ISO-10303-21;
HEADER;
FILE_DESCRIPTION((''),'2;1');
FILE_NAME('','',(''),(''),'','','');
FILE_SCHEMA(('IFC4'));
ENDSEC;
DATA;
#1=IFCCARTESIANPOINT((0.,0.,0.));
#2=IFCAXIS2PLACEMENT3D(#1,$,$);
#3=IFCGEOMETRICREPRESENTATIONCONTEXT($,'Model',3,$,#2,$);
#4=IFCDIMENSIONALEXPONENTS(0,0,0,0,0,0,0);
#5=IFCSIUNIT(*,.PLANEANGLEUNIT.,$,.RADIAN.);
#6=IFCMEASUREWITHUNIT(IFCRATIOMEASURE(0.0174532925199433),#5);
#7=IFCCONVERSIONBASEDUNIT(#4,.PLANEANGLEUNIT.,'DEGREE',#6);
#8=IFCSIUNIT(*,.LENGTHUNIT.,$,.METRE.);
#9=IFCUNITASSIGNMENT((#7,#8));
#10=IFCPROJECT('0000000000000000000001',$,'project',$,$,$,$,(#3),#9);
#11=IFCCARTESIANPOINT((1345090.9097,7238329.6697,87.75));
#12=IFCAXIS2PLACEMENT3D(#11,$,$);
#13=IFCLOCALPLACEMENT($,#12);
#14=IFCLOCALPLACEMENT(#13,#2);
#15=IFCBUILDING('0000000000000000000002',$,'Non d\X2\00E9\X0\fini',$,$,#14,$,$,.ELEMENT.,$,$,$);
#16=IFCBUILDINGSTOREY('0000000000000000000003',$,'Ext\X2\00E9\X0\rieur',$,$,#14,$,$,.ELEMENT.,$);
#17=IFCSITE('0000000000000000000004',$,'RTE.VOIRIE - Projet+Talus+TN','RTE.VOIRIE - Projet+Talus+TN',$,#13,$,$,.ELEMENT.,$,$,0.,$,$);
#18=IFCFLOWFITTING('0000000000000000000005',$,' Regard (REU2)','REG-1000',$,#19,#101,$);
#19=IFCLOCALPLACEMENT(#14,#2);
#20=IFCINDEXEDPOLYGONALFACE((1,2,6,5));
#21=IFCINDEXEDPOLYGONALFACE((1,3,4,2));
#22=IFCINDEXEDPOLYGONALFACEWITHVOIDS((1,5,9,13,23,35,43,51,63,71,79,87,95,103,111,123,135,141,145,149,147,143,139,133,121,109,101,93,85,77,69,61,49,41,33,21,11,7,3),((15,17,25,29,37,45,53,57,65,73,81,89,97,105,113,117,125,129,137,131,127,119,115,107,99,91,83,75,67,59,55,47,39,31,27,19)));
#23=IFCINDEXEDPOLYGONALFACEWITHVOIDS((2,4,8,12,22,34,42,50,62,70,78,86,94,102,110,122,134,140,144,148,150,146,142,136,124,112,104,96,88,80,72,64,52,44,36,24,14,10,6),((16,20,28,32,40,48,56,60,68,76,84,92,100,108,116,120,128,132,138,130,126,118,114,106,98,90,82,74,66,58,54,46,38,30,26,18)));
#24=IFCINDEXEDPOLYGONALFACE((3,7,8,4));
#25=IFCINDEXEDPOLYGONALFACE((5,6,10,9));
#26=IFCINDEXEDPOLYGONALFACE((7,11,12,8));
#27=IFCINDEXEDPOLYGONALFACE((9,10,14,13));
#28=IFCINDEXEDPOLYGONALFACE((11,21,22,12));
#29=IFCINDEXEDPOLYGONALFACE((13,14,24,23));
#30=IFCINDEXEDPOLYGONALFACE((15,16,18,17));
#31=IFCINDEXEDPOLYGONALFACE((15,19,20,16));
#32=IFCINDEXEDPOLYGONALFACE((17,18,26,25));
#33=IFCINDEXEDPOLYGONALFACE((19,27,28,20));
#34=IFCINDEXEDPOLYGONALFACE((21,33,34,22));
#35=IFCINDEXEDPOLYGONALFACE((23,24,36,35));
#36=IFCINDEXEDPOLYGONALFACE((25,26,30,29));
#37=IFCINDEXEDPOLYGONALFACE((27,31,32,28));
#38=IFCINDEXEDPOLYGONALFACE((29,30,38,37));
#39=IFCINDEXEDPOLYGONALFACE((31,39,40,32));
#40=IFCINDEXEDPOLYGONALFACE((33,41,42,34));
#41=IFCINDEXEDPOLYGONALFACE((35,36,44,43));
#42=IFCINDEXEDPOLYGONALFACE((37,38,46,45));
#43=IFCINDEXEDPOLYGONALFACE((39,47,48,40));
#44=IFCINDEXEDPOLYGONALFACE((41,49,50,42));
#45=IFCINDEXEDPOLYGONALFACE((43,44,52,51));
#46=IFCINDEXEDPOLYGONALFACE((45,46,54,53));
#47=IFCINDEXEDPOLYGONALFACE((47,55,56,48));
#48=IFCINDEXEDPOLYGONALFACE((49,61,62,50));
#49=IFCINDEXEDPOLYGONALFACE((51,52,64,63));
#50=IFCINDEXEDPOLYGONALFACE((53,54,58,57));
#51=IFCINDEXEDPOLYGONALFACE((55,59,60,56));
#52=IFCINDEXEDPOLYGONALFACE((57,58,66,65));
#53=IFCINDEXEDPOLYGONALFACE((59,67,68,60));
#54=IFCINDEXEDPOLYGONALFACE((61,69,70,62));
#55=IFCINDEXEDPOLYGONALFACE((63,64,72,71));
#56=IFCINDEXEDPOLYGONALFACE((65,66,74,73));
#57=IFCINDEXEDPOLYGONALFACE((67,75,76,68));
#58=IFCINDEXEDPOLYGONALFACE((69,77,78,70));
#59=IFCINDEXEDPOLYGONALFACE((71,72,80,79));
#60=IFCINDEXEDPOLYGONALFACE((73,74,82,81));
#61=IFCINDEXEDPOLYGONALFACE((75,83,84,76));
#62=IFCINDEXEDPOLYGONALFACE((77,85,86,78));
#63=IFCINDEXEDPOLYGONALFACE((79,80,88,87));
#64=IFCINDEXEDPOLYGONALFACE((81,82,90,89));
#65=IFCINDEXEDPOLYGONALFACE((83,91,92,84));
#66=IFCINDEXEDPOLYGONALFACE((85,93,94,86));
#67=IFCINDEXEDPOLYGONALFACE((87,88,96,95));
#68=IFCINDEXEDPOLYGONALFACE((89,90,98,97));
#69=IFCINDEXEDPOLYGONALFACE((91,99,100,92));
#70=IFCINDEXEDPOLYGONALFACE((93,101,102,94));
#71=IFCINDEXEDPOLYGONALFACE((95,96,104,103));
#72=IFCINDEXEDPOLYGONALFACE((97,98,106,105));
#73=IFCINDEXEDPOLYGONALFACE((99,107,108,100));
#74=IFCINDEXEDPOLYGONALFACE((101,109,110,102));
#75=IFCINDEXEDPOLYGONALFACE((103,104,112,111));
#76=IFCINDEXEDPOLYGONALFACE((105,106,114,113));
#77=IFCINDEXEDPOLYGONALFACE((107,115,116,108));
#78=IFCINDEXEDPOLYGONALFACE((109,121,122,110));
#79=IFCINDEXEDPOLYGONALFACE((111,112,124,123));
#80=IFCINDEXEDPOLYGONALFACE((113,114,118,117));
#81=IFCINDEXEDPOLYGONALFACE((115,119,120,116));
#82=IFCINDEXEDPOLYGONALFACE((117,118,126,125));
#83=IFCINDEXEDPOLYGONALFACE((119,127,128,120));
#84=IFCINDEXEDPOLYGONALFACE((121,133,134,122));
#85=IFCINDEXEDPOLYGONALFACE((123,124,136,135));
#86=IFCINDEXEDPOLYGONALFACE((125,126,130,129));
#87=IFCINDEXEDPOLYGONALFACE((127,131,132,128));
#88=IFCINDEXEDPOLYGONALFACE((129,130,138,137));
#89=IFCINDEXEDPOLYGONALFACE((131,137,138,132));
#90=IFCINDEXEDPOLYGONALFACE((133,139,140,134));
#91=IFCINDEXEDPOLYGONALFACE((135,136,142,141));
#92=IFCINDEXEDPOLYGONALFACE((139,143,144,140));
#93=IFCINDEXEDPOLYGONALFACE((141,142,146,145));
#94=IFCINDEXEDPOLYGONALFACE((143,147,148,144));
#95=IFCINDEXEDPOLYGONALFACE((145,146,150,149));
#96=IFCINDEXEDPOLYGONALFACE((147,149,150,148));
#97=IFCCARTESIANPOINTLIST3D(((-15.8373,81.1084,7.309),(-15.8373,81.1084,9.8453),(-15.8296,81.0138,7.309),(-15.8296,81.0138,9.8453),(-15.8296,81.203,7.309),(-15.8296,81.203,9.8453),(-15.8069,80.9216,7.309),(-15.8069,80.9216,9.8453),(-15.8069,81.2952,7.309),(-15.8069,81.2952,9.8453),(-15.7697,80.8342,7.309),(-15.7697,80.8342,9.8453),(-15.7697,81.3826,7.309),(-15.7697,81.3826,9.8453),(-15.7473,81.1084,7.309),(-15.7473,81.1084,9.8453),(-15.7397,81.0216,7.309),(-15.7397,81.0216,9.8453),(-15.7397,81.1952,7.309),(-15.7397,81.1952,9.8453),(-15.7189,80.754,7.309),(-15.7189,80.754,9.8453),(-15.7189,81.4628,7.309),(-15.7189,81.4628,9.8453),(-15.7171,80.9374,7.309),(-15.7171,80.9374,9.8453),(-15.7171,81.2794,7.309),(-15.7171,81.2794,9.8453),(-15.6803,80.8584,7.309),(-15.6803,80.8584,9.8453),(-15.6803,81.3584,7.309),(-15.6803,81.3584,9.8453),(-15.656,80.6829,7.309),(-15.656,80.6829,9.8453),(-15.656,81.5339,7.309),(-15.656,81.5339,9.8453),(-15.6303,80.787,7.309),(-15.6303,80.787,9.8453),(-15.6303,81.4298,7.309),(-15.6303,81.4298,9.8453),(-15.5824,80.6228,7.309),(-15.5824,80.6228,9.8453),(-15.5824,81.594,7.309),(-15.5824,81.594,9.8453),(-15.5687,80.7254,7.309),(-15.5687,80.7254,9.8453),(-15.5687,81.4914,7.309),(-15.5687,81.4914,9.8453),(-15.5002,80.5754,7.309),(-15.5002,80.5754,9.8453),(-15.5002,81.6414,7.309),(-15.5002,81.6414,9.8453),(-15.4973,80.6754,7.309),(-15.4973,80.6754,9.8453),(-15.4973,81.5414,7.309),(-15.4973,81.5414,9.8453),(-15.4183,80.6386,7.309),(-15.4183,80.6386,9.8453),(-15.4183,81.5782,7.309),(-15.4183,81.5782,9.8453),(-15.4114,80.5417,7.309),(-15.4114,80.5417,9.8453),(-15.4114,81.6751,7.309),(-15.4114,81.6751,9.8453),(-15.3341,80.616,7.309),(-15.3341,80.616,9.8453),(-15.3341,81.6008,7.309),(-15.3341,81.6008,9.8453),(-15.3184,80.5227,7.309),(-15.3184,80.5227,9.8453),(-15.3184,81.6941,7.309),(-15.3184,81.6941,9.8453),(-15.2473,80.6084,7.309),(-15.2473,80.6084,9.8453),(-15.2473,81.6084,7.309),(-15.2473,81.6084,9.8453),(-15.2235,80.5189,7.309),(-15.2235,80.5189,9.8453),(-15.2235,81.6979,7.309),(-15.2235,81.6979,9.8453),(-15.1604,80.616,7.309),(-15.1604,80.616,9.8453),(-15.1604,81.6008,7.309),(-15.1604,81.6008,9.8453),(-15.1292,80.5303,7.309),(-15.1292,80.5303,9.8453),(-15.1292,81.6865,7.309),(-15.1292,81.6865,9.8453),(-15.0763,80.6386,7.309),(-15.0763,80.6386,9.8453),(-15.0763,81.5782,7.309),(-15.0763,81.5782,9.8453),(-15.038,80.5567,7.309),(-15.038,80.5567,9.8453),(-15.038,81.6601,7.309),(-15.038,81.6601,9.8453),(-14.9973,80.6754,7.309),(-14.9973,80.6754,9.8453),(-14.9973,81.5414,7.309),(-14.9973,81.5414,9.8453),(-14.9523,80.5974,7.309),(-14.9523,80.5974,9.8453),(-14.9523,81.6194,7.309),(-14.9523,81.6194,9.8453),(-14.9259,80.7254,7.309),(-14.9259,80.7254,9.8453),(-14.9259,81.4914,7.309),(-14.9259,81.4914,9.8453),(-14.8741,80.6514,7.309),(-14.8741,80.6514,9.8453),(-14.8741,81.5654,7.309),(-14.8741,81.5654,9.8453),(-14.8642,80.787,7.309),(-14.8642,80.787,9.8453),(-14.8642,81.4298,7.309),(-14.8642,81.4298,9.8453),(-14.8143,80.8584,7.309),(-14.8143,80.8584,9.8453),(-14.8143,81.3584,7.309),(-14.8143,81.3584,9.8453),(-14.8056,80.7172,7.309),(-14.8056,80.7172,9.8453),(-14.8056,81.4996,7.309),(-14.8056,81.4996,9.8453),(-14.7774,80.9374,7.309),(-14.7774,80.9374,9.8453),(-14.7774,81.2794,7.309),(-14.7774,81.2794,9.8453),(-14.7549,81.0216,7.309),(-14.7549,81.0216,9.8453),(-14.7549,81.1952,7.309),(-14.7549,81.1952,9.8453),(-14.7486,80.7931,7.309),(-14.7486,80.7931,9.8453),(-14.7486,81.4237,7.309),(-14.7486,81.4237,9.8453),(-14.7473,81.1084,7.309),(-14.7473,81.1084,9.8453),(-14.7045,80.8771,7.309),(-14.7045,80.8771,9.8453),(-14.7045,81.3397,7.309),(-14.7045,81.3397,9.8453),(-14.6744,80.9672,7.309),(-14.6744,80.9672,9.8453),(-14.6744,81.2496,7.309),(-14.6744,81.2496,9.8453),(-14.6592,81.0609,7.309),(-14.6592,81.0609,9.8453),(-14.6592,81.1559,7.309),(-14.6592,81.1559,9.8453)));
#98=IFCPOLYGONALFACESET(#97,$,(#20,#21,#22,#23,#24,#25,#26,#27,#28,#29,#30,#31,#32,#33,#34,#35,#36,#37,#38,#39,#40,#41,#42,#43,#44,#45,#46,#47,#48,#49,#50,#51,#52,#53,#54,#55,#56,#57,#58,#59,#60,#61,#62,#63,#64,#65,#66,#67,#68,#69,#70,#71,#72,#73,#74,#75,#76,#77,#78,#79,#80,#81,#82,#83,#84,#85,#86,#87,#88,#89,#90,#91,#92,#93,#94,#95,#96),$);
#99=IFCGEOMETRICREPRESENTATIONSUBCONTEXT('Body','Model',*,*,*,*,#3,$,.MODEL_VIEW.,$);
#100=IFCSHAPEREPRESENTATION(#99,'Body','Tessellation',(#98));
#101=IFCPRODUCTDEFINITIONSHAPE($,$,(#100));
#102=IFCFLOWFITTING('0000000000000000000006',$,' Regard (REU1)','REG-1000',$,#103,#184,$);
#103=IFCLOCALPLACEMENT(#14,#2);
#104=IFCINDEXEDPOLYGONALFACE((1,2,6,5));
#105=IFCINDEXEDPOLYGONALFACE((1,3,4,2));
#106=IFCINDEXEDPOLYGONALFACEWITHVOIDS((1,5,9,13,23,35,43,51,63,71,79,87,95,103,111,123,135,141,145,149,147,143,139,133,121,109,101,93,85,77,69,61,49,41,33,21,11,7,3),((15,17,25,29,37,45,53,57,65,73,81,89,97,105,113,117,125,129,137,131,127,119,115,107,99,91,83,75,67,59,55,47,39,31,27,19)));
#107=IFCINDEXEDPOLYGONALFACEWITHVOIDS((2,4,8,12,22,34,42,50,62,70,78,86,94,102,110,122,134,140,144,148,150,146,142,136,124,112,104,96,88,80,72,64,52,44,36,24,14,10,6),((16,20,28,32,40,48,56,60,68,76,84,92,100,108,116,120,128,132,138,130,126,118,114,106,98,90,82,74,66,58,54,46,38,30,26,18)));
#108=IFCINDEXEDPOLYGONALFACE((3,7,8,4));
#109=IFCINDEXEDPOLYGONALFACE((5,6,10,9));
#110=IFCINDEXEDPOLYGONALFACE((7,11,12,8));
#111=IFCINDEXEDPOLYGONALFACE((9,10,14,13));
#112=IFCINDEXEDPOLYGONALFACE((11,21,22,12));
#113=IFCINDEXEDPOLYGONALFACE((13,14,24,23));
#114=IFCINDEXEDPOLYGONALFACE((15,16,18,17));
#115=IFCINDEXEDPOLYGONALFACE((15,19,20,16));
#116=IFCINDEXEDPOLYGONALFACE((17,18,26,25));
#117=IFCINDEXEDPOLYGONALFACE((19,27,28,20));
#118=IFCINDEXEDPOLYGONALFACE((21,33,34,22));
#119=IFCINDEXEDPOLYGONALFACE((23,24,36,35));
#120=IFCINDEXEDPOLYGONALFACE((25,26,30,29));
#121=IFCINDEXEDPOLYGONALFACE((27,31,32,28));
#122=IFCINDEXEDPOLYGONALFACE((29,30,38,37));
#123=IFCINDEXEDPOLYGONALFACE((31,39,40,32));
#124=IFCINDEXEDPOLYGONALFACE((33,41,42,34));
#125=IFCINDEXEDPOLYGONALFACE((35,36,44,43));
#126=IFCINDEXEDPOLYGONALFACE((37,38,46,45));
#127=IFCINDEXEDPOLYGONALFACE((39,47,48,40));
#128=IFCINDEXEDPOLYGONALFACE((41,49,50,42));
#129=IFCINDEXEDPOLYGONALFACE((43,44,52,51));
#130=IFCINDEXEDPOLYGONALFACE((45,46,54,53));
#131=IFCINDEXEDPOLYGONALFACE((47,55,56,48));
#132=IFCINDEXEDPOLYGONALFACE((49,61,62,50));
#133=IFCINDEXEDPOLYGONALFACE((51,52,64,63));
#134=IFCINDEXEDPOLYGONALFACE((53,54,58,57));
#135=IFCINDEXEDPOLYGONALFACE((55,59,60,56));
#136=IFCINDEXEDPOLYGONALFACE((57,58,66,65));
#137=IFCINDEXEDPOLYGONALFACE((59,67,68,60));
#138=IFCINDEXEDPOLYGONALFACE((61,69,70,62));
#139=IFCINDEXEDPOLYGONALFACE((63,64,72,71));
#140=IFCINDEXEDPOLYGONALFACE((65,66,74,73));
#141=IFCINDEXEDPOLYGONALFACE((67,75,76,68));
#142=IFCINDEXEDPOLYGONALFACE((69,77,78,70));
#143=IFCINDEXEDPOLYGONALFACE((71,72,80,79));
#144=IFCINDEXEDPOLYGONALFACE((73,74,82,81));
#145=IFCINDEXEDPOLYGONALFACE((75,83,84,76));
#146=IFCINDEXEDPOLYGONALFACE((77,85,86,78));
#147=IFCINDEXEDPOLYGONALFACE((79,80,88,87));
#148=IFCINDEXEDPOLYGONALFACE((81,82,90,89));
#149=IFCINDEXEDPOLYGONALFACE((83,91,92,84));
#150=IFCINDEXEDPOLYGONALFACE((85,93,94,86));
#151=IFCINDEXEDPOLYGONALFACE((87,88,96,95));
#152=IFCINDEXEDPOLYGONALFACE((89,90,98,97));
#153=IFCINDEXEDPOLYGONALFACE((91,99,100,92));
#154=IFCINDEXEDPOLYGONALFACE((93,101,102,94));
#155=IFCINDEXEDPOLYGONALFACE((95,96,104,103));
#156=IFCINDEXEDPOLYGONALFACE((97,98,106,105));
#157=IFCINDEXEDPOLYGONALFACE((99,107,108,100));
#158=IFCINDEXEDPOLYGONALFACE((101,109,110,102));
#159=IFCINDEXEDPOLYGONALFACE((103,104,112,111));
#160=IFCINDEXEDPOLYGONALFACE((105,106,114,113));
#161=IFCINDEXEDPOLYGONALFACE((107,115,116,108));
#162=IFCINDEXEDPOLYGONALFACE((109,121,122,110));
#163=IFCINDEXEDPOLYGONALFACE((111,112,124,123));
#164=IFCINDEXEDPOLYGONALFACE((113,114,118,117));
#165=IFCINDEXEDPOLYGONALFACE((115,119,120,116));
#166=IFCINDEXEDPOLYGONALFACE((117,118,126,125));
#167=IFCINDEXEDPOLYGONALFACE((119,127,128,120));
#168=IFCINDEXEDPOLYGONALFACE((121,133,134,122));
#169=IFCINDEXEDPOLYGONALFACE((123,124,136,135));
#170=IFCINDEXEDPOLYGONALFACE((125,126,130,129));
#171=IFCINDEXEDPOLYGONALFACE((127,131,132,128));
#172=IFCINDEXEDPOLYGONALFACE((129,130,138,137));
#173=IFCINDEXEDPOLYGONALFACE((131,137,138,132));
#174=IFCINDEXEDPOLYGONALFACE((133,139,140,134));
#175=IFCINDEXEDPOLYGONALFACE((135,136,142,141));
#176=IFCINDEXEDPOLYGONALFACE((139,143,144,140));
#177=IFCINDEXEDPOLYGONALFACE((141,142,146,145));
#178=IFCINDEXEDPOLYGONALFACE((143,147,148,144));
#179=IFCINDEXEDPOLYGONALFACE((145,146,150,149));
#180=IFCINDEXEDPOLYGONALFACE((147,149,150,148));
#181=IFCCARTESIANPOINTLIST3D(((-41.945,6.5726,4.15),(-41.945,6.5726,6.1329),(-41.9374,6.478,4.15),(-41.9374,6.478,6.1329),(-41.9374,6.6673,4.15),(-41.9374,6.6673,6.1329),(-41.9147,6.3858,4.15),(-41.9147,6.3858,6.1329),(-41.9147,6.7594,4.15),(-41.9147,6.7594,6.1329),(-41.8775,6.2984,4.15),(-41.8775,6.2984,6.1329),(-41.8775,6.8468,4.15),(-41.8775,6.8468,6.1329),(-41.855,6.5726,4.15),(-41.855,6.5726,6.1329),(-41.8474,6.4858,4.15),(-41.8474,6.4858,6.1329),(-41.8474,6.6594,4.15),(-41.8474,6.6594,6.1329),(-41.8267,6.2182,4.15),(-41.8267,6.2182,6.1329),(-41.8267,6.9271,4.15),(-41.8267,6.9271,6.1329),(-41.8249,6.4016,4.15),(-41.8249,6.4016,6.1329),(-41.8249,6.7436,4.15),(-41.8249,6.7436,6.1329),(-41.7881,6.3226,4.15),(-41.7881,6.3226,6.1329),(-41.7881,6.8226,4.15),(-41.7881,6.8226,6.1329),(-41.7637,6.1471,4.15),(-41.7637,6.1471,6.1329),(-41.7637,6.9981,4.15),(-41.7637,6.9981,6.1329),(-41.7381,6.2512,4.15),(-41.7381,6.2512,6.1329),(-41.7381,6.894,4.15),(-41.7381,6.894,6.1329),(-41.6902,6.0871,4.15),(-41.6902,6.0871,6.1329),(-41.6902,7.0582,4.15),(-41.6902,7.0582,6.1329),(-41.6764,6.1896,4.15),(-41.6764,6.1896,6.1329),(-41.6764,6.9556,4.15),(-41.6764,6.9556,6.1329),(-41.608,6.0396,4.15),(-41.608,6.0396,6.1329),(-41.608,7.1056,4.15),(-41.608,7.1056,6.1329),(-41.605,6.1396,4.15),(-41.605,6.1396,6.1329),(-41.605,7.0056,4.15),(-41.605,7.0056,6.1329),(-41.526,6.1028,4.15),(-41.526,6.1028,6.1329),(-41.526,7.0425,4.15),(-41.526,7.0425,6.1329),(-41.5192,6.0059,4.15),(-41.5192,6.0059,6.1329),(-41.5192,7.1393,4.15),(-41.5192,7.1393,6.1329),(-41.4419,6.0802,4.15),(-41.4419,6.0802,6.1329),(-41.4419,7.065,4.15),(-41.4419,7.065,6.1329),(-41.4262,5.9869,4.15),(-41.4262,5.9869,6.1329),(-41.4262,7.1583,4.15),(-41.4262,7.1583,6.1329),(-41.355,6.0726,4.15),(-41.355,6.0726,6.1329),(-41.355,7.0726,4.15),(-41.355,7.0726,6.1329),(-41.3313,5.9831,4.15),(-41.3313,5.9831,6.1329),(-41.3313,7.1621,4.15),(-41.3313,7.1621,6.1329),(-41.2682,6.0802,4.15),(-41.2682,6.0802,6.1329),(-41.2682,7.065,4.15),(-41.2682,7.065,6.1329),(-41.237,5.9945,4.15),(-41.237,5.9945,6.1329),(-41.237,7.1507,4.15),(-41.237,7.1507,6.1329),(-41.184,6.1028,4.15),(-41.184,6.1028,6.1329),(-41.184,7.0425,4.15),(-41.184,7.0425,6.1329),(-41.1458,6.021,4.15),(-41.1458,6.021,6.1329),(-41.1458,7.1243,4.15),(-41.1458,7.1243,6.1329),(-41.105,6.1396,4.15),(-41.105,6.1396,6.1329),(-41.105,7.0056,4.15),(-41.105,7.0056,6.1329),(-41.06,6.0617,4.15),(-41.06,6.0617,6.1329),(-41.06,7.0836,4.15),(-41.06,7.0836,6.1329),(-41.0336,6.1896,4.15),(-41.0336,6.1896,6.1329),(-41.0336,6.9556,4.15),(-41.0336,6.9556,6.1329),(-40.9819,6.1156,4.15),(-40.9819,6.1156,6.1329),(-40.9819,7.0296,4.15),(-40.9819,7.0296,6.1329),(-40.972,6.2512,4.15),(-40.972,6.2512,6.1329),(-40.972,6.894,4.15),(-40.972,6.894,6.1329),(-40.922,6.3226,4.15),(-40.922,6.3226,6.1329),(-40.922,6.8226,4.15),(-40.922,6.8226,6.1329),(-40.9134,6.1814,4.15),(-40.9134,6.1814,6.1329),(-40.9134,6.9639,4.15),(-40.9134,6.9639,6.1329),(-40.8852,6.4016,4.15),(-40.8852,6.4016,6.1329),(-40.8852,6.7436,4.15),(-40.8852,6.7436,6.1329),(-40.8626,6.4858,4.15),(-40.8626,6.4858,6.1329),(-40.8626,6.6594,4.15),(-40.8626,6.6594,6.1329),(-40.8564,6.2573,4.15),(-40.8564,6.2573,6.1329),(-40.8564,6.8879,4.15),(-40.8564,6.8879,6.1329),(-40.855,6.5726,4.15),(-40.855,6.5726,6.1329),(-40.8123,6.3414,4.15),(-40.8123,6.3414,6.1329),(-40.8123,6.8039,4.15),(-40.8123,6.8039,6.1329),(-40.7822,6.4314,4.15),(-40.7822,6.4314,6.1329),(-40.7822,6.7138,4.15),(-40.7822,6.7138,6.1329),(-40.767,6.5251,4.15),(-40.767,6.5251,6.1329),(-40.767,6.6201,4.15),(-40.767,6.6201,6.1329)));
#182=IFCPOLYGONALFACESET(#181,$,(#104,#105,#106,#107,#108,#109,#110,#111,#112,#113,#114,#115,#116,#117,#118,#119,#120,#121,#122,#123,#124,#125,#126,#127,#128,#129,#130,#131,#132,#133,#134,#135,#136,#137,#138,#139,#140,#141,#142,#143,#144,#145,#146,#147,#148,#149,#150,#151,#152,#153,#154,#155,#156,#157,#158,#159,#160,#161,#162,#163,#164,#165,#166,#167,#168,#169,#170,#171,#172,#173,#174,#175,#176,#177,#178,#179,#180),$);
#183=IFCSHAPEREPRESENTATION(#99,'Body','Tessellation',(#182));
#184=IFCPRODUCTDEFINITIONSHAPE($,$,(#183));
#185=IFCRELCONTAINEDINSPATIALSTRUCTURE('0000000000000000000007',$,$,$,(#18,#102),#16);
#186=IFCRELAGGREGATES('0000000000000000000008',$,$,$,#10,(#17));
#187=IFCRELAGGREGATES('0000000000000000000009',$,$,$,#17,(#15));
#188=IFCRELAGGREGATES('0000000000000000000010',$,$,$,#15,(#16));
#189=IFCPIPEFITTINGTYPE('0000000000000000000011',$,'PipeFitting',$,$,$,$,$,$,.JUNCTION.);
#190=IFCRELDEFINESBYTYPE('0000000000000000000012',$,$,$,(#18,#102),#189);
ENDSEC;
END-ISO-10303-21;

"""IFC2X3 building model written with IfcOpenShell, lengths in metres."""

from ifc_helpers import new_model, entity, si_unit, converted_unit, frame, origin, origin_2d_with_axis, place, context, subcontext, project, spatial, hollow_circle, extrude, type_object, element, save


model = new_model("IFC2X3")

# Units and contexts
model_context = context("Model", 3, world=origin())
body_context = subcontext(model_context, "Body", "Model", "MODEL_VIEW")
ifc_project = project(units=[converted_unit("PLANEANGLEUNIT", "DEGREE", entity("IfcRatioMeasure", 0.0174532925199433), si_unit("PLANEANGLEUNIT", "RADIAN"), dimensions=[0, 0, 0, 0, 0, 0, 0]), si_unit("LENGTHUNIT", "METRE")], contexts=[model_context])

# Site, building, storey
site_placement = place(None, frame((1345090.9097, 7238329.6697, 87.75)))
site = spatial("IfcSite", under=ifc_project, at=site_placement, Name="RTE.VOIRIE - Projet+Talus+TN", Description="RTE.VOIRIE - Projet+Talus+TN", CompositionType="ELEMENT", RefElevation=0.0)
placement = place(site_placement, origin())
building = spatial("IfcBuilding", under=site, at=placement, Name="Non défini", CompositionType="ELEMENT")
storey = spatial("IfcBuildingStorey", under=building, at=placement, Name="Extérieur", CompositionType="ELEMENT")

# Flow fittings
pipe_fitting_type_1 = type_object("IfcPipeFittingType", Name="PipeFitting", PredefinedType="JUNCTION")
flow_fitting_1_placement = place(placement, origin())
element("IfcFlowFitting", 1, at=flow_fitting_1_placement, inside=storey, type_object=pipe_fitting_type_1, Name=" Regard (REU2)", Description="REG-1000", context=body_context, shape_type="SweptSolid", body=[
    extrude(hollow_circle(Radius=0.59, WallThickness=0.09, at=origin_2d_with_axis()), frame((-15.2473, 81.1084, 7.309), z_axis=(0.0, 0.0, 1.0), x_axis=(-1.0, 0.0, 0.0)), (0.0, 0.0, 1.0), 2.5363),
])
flow_fitting_2_placement = place(placement, origin())
element("IfcFlowFitting", 2, at=flow_fitting_2_placement, inside=storey, type_object=pipe_fitting_type_1, Name=" Regard (REU1)", Description="REG-1000", context=body_context, shape_type="SweptSolid", body=[
    extrude(hollow_circle(Radius=0.59, WallThickness=0.09, at=origin_2d_with_axis()), frame((-41.355, 6.5726, 4.15), z_axis=(0.0, 0.0, 1.0), x_axis=(-1.0, 0.0, 0.0)), (0.0, 0.0, 1.0), 1.9829),
])

save(model, "model.ifc")
